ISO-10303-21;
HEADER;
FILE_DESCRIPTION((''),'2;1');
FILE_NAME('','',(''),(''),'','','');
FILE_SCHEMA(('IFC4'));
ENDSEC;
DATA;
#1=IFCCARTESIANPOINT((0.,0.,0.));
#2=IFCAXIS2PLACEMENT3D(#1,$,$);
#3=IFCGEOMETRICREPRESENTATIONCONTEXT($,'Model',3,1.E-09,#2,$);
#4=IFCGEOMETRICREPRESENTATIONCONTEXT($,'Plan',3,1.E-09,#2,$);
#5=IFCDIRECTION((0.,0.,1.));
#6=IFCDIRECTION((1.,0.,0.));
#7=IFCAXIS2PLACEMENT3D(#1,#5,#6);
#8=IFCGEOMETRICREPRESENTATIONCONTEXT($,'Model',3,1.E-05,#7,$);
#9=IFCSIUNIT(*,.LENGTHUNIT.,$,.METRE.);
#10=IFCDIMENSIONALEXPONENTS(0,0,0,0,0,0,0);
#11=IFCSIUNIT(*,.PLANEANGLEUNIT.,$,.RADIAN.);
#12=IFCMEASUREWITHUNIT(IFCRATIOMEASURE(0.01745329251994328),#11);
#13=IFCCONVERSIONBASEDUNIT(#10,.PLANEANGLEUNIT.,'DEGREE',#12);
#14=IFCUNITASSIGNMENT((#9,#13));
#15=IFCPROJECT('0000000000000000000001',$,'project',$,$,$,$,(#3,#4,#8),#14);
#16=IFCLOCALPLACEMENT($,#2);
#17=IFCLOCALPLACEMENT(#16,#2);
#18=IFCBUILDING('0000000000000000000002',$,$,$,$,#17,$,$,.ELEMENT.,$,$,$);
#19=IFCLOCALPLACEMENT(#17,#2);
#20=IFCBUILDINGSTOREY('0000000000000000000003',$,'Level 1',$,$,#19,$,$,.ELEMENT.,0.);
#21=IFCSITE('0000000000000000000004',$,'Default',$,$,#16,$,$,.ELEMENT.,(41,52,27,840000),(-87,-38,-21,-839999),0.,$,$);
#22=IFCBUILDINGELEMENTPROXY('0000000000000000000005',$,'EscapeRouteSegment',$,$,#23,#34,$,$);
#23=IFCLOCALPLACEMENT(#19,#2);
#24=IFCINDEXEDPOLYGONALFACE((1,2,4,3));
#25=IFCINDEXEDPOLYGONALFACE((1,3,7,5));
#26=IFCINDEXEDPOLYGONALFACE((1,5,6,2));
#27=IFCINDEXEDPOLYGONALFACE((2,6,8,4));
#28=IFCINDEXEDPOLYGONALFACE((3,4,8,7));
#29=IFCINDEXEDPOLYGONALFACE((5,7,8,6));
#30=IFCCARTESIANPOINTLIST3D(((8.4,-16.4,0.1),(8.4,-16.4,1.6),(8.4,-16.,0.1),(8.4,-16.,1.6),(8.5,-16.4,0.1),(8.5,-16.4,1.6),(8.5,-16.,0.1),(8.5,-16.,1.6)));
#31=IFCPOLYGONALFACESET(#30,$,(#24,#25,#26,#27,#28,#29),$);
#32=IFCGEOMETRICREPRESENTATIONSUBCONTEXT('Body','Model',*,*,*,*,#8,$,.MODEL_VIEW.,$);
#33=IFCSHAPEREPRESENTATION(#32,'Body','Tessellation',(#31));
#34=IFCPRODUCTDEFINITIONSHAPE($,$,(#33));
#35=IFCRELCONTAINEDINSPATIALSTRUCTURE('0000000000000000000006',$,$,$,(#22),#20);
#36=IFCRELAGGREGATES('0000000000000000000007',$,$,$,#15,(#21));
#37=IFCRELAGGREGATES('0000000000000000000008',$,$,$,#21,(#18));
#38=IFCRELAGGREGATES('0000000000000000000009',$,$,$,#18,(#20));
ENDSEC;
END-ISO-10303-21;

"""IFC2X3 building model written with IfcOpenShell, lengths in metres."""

from ifc_helpers import new_model, entity, si_unit, converted_unit, frame, origin, origin_with_axes, place, context, subcontext, project, spatial, polyline, outline, extrude, element, save


model = new_model("IFC2X3")

# Units and contexts
model_context_1 = context("Model", 3, precision=1e-09, world=origin())
plan_context = context("Plan", 3, precision=1e-09, world=origin())
model_context_2 = context("Model", 3, precision=1e-05, world=origin_with_axes())
body_context = subcontext(model_context_2, "Body", "Model", "MODEL_VIEW")
ifc_project = project(units=[si_unit("LENGTHUNIT", "METRE"), converted_unit("PLANEANGLEUNIT", "DEGREE", entity("IfcRatioMeasure", 0.01745329251994328), si_unit("PLANEANGLEUNIT", "RADIAN"), dimensions=[0, 0, 0, 0, 0, 0, 0])], contexts=[model_context_1, plan_context, model_context_2])

# Site, building, storey
site_placement = place(None, origin())
site = spatial("IfcSite", under=ifc_project, at=site_placement, Name="Default", CompositionType="ELEMENT", RefLatitude=(41, 52, 27, 840000), RefLongitude=(-87, -38, -21, -839999), RefElevation=0.0)
building_placement = place(site_placement, origin())
building = spatial("IfcBuilding", under=site, at=building_placement, CompositionType="ELEMENT")
storey_placement = place(building_placement, origin())
storey = spatial("IfcBuildingStorey", under=building, at=storey_placement, Name="Level 1", CompositionType="ELEMENT", Elevation=0.0)

# Building element proxy
proxy_1_placement = place(storey_placement, frame((8.4, -16.2, 0.1), z_axis=(0.0, 0.0, 1.0), x_axis=(1.0, 0.0, 0.0)))
element("IfcBuildingElementProxy", 1, at=proxy_1_placement, inside=storey, Name="EscapeRouteSegment", context=body_context, shape_type="SweptSolid", body=[
    extrude(outline(polyline([(0.0, -0.2), (0.0, 0.2), (0.1, 0.2), (0.1, -0.2), (0.0, -0.2)])), origin_with_axes(), (0.0, 0.0, 1.0), 1.5),
])

save(model, "model.ifc")
